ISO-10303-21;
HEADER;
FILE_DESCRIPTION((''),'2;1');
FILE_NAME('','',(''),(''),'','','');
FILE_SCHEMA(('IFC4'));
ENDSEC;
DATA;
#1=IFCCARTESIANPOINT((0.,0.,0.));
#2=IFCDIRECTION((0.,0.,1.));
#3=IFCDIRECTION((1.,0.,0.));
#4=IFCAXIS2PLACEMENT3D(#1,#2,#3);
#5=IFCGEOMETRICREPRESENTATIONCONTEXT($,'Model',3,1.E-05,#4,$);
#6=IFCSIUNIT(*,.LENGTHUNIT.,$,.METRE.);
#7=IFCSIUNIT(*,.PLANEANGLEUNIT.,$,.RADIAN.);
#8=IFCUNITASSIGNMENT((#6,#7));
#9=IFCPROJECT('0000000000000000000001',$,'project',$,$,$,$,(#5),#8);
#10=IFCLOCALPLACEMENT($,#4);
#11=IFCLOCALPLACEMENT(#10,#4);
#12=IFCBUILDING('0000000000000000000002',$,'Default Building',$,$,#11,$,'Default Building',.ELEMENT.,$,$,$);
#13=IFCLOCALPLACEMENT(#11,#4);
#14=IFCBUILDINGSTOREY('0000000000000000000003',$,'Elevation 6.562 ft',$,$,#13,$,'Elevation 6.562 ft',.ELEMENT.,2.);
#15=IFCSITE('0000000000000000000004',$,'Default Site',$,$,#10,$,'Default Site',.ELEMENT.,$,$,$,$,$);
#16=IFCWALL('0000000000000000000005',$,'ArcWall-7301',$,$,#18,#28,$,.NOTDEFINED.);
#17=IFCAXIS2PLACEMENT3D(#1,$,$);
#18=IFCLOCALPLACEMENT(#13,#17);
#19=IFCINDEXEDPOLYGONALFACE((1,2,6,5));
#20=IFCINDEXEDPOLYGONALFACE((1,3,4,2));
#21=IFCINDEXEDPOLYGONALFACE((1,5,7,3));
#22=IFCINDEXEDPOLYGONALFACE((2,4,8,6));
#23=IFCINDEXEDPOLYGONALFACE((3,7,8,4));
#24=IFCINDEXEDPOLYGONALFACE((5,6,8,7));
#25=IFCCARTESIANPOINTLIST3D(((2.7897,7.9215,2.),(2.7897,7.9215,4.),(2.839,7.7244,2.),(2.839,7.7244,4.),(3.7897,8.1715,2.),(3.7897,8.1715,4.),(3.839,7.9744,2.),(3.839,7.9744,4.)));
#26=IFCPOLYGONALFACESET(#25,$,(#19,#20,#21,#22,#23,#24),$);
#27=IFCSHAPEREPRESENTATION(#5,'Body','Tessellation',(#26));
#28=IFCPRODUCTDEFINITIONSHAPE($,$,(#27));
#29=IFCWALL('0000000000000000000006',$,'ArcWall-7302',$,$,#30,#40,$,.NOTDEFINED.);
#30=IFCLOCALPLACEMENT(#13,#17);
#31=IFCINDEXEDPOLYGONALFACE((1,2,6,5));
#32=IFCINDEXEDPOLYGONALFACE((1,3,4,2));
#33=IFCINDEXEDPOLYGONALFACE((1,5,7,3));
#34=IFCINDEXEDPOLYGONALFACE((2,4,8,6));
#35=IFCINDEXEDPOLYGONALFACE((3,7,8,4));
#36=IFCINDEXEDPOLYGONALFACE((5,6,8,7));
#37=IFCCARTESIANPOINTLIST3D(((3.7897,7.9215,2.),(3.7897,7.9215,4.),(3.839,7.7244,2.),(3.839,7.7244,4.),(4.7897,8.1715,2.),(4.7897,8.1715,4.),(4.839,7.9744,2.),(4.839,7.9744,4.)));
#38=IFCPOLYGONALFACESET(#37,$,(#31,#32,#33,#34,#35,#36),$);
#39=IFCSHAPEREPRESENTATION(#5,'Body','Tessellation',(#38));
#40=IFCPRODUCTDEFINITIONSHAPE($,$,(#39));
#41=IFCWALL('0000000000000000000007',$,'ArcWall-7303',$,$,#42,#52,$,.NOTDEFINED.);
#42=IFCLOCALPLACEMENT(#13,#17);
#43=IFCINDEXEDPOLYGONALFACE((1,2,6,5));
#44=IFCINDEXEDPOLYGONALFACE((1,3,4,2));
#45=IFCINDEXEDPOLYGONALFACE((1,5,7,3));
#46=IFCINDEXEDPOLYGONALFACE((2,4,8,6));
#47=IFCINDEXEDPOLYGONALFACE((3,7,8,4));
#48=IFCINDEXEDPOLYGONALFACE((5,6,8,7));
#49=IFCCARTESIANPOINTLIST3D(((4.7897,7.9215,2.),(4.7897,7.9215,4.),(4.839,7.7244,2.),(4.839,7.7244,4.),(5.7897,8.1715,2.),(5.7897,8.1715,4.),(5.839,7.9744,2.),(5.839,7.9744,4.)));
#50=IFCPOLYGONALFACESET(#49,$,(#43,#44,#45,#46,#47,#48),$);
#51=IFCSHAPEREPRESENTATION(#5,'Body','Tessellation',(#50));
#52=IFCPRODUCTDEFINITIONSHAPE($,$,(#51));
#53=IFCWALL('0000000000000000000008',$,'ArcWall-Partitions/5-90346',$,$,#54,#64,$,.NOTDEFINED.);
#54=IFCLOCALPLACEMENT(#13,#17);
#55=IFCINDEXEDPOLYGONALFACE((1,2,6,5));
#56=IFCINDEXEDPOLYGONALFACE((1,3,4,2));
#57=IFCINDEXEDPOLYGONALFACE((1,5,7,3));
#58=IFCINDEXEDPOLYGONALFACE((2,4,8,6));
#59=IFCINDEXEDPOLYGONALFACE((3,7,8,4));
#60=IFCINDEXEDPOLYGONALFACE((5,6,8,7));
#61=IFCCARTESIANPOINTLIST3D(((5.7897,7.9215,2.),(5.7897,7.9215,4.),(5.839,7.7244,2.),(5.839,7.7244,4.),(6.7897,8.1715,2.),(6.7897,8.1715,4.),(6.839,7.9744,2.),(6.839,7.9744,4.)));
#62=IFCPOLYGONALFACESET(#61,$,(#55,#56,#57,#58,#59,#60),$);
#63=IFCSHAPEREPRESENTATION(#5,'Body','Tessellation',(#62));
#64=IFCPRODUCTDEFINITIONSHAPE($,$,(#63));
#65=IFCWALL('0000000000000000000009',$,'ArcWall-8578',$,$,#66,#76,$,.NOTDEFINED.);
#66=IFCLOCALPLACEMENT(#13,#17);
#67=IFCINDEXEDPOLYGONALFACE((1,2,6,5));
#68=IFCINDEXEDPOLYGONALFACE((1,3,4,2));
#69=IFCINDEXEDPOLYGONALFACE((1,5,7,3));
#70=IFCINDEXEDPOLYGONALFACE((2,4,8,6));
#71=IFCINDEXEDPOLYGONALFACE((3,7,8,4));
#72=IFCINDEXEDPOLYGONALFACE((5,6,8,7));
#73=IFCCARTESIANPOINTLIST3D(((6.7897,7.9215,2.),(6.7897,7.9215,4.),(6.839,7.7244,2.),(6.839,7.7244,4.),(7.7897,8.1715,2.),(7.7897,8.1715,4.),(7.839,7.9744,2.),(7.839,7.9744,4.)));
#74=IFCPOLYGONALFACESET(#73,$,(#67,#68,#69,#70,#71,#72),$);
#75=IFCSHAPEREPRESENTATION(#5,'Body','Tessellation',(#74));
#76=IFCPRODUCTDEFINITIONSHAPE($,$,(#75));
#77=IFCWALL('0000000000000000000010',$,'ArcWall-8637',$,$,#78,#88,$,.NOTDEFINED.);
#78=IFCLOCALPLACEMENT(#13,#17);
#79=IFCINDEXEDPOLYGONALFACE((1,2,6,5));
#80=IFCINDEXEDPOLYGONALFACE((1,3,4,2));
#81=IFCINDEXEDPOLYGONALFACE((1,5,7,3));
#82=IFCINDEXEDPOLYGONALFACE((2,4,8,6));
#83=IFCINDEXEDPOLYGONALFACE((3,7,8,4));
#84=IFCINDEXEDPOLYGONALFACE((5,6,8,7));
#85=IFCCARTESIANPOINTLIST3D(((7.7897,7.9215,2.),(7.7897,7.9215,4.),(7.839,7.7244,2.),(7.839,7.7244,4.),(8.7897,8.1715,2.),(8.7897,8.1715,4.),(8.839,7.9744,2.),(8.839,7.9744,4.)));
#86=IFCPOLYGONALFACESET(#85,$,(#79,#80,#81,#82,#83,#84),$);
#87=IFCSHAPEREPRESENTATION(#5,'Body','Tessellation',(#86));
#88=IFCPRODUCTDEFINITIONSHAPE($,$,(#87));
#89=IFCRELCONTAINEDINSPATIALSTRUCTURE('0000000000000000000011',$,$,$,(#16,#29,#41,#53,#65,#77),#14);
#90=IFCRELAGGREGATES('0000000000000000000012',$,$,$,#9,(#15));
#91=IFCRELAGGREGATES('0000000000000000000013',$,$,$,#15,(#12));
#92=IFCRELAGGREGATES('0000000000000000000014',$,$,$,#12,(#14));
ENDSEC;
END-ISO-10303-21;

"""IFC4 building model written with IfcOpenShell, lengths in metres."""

from ifc_helpers import new_model, si_unit, frame, origin_with_axes, origin_2d_with_axis, place, context, project, spatial, rectangle, extrude, element, save


model = new_model("IFC4")

# Units and contexts
model_context = context("Model", 3, precision=1e-05, world=origin_with_axes())
ifc_project = project(units=[si_unit("LENGTHUNIT", "METRE"), si_unit("PLANEANGLEUNIT", "RADIAN")], contexts=[model_context])

# Site, building, storey
site_placement = place(None, origin_with_axes())
site = spatial("IfcSite", under=ifc_project, at=site_placement, Name="Default Site", LongName="Default Site", CompositionType="ELEMENT")
building_placement = place(site_placement, origin_with_axes())
building = spatial("IfcBuilding", under=site, at=building_placement, Name="Default Building", LongName="Default Building", CompositionType="ELEMENT")
storey_placement = place(building_placement, origin_with_axes())
storey = spatial("IfcBuildingStorey", under=building, at=storey_placement, Name="Elevation 6.562 ft", LongName="Elevation 6.562 ft", CompositionType="ELEMENT", Elevation=2.0)

# Walls
for number, where, z_axis, x_axis, name in (
    (1, (3.3144, 7.948, 2.0), (0.0, 0.0, 1.0), (0.970143, 0.242536, 0.0), "ArcWall-7301"),
    (2, (4.3144, 7.948, 2.0), (0.0, 0.0, 1.0), (0.970143, 0.242536, 0.0), "ArcWall-7302"),
    (3, (5.3144, 7.948, 2.0), (0.0, 0.0, 1.0), (0.970143, 0.242536, 0.0), "ArcWall-7303"),
    (4, (6.3144, 7.948, 2.0), (0.0, 0.0, 1.0), (0.970143, 0.242536, 0.0), "ArcWall-Partitions/5-90346"),
    (5, (7.3144, 7.948, 2.0), (0.0, 0.0, 1.0), (0.970143, 0.242536, 0.0), "ArcWall-8578"),
    (6, (8.3144, 7.948, 2.0), (0.0, 0.0, 1.0), (0.970143, 0.242536, 0.0), "ArcWall-8637"),
):
    element("IfcWall", number, at=place(storey_placement, frame(where, z_axis=z_axis, x_axis=x_axis)), inside=storey, Name=name, PredefinedType="NOTDEFINED", context=model_context, shape_type="SweptSolid", body=[
        extrude(rectangle(XDim=1.0308, YDim=0.2032, at=origin_2d_with_axis()), origin_with_axes(), (0.0, 0.0, 1.0), 2.0),
    ])

save(model, "model.ifc")
